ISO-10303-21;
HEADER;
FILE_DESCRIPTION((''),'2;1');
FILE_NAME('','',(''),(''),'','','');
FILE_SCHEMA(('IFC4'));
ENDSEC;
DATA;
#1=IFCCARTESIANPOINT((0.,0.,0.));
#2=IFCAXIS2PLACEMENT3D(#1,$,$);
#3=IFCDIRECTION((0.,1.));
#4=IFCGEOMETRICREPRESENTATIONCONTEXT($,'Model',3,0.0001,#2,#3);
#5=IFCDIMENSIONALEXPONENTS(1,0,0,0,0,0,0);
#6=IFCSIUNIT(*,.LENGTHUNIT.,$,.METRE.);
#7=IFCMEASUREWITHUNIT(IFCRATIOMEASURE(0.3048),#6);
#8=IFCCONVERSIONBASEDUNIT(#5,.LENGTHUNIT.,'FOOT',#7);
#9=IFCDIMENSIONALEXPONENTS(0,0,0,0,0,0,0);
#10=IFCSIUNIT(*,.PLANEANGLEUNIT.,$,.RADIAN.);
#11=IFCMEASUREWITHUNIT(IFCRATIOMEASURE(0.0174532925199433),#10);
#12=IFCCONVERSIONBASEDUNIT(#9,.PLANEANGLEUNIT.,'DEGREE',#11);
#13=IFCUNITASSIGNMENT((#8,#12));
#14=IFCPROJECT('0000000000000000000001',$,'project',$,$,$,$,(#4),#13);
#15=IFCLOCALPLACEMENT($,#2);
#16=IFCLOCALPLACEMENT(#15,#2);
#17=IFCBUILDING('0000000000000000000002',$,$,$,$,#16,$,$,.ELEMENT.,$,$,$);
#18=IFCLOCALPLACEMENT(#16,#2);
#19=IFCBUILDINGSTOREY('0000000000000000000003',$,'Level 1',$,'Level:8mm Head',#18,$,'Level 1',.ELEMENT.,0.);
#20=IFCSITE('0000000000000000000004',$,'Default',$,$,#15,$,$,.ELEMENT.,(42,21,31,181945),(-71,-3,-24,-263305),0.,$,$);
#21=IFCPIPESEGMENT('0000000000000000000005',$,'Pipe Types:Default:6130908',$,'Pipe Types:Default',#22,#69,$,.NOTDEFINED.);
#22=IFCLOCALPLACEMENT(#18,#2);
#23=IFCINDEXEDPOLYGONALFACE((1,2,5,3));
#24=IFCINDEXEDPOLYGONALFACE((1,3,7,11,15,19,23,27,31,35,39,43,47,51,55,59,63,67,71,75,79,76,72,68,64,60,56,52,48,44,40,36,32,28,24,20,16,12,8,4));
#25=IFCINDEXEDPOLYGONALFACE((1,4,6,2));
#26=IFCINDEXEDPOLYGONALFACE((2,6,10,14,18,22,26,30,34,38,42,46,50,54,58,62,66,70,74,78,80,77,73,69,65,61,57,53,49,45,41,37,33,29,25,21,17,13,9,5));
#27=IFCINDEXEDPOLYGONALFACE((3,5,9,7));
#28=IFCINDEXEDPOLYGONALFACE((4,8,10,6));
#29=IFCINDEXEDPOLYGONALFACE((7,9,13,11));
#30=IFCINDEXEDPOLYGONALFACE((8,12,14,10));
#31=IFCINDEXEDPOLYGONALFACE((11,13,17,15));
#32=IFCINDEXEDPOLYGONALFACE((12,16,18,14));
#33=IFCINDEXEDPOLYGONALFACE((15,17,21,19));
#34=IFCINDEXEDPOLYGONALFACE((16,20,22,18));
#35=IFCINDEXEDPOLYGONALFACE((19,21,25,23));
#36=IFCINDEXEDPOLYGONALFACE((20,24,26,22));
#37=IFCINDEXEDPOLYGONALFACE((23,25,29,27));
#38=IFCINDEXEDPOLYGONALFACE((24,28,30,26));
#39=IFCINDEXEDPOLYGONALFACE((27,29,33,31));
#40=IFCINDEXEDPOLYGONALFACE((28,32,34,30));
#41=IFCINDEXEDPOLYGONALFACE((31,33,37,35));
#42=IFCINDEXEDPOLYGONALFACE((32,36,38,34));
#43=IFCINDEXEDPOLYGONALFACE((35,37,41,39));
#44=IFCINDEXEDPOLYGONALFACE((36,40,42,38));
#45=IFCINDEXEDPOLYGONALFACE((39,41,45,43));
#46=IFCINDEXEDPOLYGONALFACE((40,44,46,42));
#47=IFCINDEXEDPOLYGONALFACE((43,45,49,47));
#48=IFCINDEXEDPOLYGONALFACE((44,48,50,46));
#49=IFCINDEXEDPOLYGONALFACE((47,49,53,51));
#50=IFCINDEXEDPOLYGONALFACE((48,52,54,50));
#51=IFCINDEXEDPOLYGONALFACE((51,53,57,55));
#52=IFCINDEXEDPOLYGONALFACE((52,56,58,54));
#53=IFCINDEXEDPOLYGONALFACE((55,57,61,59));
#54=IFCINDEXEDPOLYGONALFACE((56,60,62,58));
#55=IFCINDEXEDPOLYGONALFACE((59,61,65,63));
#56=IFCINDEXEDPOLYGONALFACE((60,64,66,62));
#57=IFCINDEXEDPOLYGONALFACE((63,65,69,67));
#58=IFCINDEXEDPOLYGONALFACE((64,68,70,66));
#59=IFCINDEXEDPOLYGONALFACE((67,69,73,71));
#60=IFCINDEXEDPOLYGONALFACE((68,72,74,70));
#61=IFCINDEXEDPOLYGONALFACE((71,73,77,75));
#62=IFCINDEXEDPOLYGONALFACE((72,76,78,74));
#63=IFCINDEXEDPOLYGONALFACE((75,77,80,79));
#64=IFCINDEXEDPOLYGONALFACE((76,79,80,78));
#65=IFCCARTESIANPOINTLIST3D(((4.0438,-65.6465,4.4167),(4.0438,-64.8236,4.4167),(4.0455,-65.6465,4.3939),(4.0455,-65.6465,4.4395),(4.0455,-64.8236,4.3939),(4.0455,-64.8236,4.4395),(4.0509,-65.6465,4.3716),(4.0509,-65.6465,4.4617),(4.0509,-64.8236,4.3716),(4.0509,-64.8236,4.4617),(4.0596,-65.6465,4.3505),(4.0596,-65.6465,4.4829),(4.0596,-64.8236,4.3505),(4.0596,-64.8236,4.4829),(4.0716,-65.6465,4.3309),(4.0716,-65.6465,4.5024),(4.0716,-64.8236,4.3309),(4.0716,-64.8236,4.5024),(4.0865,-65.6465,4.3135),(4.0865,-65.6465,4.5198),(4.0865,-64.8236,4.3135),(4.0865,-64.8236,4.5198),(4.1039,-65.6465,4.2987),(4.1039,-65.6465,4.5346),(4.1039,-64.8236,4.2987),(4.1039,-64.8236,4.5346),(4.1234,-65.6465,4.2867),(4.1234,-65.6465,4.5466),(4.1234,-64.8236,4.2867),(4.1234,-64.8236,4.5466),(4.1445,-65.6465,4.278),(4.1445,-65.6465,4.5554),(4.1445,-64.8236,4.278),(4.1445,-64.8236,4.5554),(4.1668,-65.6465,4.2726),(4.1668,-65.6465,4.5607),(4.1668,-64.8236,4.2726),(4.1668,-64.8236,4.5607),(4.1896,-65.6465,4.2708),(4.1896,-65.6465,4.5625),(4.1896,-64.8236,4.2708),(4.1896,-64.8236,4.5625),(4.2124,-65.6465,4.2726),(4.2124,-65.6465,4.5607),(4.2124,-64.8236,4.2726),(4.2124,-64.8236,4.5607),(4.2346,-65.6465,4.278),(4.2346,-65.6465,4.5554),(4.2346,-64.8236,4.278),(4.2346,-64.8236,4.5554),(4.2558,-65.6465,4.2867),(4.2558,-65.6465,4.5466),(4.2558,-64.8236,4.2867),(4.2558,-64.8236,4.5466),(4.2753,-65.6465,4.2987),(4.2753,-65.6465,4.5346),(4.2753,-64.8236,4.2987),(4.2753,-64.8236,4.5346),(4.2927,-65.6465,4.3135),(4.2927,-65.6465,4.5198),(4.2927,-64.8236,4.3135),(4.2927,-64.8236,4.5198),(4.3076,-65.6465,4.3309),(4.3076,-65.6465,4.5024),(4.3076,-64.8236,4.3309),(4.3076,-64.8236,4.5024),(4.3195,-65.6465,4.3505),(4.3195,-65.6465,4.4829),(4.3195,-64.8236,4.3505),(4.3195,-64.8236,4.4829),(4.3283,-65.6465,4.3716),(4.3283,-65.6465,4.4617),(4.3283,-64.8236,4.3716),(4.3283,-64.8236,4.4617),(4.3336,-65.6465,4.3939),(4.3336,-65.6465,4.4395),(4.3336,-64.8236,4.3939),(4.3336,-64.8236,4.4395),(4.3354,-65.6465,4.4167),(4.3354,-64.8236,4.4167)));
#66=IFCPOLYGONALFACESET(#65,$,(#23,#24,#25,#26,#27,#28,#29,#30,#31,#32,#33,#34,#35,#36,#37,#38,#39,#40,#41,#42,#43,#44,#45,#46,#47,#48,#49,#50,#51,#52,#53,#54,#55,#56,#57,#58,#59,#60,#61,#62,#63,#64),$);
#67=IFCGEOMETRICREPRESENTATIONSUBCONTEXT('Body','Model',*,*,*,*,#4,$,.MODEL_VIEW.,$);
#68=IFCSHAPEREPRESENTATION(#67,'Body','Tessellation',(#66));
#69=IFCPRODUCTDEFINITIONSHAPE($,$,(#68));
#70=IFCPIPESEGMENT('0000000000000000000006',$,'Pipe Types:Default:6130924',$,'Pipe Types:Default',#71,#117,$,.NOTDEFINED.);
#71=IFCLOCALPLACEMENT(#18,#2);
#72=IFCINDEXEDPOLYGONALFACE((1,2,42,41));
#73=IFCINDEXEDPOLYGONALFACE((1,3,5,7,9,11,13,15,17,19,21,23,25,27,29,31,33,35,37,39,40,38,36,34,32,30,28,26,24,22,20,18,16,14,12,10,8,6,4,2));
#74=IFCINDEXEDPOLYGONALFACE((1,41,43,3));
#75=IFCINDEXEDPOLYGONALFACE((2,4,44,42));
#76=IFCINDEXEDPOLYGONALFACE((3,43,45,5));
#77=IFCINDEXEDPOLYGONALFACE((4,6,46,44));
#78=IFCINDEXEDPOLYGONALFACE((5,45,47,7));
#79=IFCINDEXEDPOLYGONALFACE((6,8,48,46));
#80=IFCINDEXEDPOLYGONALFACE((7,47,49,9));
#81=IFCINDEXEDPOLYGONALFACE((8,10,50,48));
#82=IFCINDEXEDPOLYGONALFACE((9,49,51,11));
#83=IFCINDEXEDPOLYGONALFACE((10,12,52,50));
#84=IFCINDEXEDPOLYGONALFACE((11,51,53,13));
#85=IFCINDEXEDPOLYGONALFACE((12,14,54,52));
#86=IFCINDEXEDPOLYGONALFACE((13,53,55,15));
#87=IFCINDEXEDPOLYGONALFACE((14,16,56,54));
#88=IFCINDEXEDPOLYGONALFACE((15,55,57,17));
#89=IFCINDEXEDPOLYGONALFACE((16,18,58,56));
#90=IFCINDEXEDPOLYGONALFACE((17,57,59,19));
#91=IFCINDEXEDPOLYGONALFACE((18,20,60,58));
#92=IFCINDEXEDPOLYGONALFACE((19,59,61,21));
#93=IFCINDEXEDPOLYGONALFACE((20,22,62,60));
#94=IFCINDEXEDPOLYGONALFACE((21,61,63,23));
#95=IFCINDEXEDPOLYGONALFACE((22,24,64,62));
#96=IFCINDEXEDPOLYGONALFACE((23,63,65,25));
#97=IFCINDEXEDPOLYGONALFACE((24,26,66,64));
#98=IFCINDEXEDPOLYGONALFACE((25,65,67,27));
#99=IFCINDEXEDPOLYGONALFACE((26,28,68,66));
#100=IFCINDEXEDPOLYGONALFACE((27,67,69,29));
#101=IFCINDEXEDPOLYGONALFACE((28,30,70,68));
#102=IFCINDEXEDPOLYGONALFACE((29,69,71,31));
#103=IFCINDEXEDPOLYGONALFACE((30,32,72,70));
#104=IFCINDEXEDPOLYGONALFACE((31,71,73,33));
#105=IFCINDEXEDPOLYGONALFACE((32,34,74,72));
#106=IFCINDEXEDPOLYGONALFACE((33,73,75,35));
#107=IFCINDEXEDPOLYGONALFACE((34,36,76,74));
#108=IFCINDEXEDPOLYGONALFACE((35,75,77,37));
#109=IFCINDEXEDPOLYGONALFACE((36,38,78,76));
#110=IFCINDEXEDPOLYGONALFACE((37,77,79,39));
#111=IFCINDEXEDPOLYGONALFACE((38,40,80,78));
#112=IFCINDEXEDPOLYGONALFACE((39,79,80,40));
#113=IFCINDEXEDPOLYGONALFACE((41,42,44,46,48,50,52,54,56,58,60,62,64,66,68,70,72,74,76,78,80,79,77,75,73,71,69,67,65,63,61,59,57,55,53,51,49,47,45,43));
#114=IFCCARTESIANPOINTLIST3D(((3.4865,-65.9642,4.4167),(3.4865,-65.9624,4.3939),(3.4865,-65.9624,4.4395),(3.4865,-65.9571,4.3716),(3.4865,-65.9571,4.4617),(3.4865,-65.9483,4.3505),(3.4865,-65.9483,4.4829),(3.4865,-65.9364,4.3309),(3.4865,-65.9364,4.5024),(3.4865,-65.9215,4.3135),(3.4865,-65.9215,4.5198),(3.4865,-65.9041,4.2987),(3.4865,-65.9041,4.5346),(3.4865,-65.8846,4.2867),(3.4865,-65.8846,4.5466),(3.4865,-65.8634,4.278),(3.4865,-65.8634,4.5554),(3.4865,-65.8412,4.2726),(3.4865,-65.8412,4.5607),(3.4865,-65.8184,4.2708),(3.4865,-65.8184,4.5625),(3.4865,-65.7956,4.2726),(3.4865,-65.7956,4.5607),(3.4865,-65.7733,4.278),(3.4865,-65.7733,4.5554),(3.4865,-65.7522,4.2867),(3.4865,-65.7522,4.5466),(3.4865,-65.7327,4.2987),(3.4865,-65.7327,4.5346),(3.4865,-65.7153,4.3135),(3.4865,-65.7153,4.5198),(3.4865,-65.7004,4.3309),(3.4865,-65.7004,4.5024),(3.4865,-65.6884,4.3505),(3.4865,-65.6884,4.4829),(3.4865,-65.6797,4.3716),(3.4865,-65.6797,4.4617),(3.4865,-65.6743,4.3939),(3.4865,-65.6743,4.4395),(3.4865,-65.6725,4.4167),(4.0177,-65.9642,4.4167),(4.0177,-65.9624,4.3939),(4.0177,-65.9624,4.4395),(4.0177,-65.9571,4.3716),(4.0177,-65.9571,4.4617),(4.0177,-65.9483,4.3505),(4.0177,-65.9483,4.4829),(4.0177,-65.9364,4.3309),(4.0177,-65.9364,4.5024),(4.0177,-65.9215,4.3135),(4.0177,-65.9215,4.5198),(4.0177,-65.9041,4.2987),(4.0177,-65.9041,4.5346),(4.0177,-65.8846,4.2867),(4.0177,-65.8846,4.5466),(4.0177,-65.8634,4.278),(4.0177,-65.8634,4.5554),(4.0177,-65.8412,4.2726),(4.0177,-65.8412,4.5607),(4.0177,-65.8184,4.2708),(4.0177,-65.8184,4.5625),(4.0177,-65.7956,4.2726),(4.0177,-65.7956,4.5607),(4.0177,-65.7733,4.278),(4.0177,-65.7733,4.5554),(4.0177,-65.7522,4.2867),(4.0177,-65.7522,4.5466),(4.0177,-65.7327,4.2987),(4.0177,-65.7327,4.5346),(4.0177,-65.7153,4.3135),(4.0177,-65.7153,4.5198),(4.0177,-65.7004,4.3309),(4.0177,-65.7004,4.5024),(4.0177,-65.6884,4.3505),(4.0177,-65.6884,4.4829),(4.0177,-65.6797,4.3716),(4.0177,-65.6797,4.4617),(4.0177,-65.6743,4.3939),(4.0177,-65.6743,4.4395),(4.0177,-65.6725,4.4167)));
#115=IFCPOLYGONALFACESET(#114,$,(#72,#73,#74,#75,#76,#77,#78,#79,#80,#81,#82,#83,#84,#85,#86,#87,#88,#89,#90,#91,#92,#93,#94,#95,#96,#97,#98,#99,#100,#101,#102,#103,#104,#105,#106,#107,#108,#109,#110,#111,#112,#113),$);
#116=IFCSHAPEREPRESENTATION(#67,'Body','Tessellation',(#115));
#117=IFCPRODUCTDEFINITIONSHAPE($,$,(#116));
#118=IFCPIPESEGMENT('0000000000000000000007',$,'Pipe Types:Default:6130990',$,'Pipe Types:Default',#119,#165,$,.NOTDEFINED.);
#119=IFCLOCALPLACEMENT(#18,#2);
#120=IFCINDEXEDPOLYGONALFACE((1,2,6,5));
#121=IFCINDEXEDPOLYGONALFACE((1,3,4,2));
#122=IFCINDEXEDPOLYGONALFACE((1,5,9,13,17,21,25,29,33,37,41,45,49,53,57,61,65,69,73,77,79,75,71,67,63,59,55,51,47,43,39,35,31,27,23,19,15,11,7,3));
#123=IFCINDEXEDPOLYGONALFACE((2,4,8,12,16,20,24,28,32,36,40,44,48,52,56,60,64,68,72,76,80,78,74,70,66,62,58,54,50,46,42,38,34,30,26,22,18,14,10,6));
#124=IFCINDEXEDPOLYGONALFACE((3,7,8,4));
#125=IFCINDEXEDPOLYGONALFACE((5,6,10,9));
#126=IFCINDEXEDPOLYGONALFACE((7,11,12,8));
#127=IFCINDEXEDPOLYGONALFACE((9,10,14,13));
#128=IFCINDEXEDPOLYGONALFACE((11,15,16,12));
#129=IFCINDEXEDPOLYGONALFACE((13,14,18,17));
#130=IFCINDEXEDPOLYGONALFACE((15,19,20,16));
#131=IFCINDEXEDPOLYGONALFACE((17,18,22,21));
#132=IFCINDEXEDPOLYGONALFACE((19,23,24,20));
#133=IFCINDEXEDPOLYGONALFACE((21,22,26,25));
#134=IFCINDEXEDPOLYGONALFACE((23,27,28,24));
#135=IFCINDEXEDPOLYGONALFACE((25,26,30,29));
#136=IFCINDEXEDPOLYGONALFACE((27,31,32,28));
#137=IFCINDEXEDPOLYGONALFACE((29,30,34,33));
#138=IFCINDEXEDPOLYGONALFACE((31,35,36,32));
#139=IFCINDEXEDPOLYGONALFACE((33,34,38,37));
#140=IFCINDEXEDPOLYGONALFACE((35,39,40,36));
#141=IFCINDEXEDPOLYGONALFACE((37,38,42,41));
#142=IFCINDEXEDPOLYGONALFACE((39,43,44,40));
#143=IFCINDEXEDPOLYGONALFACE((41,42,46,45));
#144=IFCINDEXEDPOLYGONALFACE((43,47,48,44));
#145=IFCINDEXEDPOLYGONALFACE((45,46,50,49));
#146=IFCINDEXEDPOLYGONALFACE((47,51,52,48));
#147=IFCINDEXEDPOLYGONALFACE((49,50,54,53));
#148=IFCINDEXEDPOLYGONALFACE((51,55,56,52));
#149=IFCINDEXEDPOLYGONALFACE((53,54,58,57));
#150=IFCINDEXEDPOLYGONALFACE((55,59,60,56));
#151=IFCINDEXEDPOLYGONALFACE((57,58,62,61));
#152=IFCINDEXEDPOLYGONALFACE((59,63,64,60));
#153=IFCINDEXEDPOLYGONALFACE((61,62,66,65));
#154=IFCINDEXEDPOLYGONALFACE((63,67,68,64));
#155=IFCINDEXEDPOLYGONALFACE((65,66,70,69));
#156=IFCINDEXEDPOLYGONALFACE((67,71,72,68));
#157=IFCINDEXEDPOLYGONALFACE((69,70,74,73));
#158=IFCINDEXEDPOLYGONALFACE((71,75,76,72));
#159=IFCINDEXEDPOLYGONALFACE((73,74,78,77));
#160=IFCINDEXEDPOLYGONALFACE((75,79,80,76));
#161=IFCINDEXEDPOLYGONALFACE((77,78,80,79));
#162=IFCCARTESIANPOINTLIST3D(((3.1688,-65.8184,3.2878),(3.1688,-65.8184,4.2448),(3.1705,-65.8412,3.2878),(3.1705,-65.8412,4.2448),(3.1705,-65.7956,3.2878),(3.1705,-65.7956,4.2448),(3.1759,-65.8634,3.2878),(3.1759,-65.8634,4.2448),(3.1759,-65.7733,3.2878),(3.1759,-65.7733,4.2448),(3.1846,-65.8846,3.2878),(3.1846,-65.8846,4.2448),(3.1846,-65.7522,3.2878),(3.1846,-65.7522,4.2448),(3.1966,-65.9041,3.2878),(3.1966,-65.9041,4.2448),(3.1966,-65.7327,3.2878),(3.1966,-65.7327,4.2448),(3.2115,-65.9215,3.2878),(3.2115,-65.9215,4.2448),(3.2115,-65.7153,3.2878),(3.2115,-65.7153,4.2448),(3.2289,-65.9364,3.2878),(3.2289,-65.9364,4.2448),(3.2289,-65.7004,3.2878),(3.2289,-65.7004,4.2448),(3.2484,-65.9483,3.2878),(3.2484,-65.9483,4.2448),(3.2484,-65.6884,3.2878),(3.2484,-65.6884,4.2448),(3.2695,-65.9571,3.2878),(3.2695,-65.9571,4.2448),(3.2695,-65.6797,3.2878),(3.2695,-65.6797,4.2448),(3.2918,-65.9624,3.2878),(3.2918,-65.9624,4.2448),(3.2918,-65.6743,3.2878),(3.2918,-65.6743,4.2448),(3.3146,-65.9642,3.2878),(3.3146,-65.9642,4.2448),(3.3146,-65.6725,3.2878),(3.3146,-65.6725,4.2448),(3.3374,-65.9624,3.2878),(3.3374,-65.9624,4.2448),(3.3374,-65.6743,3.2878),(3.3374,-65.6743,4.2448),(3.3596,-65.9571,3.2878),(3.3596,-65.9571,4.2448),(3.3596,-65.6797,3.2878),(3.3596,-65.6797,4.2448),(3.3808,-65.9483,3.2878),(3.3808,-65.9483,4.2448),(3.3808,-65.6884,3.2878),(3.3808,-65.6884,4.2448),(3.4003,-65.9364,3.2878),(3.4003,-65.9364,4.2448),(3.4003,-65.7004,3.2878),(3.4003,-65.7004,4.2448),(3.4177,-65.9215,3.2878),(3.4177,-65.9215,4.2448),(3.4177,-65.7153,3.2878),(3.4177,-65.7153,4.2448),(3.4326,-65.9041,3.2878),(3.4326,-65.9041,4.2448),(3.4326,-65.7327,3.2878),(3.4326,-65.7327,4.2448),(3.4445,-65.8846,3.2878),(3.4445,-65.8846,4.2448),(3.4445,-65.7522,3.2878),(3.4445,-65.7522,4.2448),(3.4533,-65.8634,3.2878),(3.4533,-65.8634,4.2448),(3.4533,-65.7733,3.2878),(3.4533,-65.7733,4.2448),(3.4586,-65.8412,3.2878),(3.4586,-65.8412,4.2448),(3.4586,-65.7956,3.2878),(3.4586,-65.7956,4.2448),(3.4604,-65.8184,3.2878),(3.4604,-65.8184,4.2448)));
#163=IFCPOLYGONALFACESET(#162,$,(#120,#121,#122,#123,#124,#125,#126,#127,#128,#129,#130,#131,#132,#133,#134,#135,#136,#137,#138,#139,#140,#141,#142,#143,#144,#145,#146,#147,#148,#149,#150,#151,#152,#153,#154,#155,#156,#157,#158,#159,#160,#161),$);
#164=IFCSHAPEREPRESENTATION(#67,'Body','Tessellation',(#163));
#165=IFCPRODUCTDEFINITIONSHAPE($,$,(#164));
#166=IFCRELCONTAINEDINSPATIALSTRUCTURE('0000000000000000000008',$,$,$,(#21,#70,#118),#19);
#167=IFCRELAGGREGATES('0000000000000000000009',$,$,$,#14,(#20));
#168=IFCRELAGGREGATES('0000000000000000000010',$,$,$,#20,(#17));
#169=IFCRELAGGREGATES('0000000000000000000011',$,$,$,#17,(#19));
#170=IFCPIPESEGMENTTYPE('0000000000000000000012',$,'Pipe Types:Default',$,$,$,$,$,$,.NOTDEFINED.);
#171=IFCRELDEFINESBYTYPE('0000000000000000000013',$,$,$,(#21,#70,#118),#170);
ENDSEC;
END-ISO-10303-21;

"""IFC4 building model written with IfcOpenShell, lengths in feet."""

from ifc_helpers import new_model, entity, si_unit, converted_unit, direction, frame, origin, place, context, subcontext, project, spatial, indexed_curve, outline, extrude, type_object, element, save


model = new_model("IFC4")

# Units and contexts
model_context = context("Model", 3, precision=0.0001, world=origin(), true_north=direction((0.0, 1.0)))
body_context = subcontext(model_context, "Body", "Model", "MODEL_VIEW")
ifc_project = project(units=[converted_unit("LENGTHUNIT", "FOOT", entity("IfcRatioMeasure", 0.3048), si_unit("LENGTHUNIT", "METRE"), dimensions=[1, 0, 0, 0, 0, 0, 0]), converted_unit("PLANEANGLEUNIT", "DEGREE", entity("IfcRatioMeasure", 0.0174532925199433), si_unit("PLANEANGLEUNIT", "RADIAN"), dimensions=[0, 0, 0, 0, 0, 0, 0])], contexts=[model_context])

# Site, building, storey
site_placement = place(None, origin())
site = spatial("IfcSite", under=ifc_project, at=site_placement, Name="Default", CompositionType="ELEMENT", RefLatitude=(42, 21, 31, 181945), RefLongitude=(-71, -3, -24, -263305), RefElevation=0.0)
building_placement = place(site_placement, origin())
building = spatial("IfcBuilding", under=site, at=building_placement, CompositionType="ELEMENT")
storey_placement = place(building_placement, origin())
storey = spatial("IfcBuildingStorey", under=building, at=storey_placement, Name="Level 1", ObjectType="Level:8mm Head", LongName="Level 1", CompositionType="ELEMENT", Elevation=0.0)

# Pipe segments
pipe_segment_type = type_object("IfcPipeSegmentType", Name="Pipe Types:Default", PredefinedType="NOTDEFINED")
pipe_segment_1_placement = place(storey_placement, origin())
element("IfcPipeSegment", 1, at=pipe_segment_1_placement, inside=storey, type_object=pipe_segment_type, Name="Pipe Types:Default:6130908", ObjectType="Pipe Types:Default", PredefinedType="NOTDEFINED", context=body_context, shape_type="SweptSolid", body=[
    extrude(outline(indexed_curve([(0.1458, 0.0), (0.144, 0.0228), (0.1387, 0.0451), (0.1299, 0.0662), (0.118, 0.0857), (0.1031, 0.1031), (0.0857, 0.118), (0.0662, 0.1299), (0.0451, 0.1387), (0.0228, 0.144), (0.0, 0.1458), (-0.0228, 0.144), (-0.0451, 0.1387), (-0.0662, 0.1299), (-0.0857, 0.118), (-0.1031, 0.1031), (-0.118, 0.0857), (-0.1299, 0.0662), (-0.1387, 0.0451), (-0.144, 0.0228), (-0.1458, 0.0), (-0.144, -0.0228), (-0.1387, -0.0451), (-0.1299, -0.0662), (-0.118, -0.0857), (-0.1031, -0.1031), (-0.0857, -0.118), (-0.0662, -0.1299), (-0.0451, -0.1387), (-0.0228, -0.144), (0.0, -0.1458), (0.0228, -0.144), (0.0451, -0.1387), (0.0662, -0.1299), (0.0857, -0.118), (0.1031, -0.1031), (0.118, -0.0857), (0.1299, -0.0662), (0.1387, -0.0451), (0.144, -0.0228), (0.1458, 0.0)], self_intersect=False)), frame((4.1896, -65.6465, 4.4167), z_axis=(0.0, 1.0, 0.0), x_axis=(-1.0, 0.0, 0.0)), (0.0, 0.0, 1.0), 0.8229),
])
pipe_segment_2_placement = place(storey_placement, origin())
element("IfcPipeSegment", 2, at=pipe_segment_2_placement, inside=storey, type_object=pipe_segment_type, Name="Pipe Types:Default:6130924", ObjectType="Pipe Types:Default", PredefinedType="NOTDEFINED", context=body_context, shape_type="SweptSolid", body=[
    extrude(outline(indexed_curve([(0.1458, 0.0), (0.144, 0.0228), (0.1387, 0.0451), (0.1299, 0.0662), (0.118, 0.0857), (0.1031, 0.1031), (0.0857, 0.118), (0.0662, 0.1299), (0.0451, 0.1387), (0.0228, 0.144), (0.0, 0.1458), (-0.0228, 0.144), (-0.0451, 0.1387), (-0.0662, 0.1299), (-0.0857, 0.118), (-0.1031, 0.1031), (-0.118, 0.0857), (-0.1299, 0.0662), (-0.1387, 0.0451), (-0.144, 0.0228), (-0.1458, 0.0), (-0.144, -0.0228), (-0.1387, -0.0451), (-0.1299, -0.0662), (-0.118, -0.0857), (-0.1031, -0.1031), (-0.0857, -0.118), (-0.0662, -0.1299), (-0.0451, -0.1387), (-0.0228, -0.144), (0.0, -0.1458), (0.0228, -0.144), (0.0451, -0.1387), (0.0662, -0.1299), (0.0857, -0.118), (0.1031, -0.1031), (0.118, -0.0857), (0.1299, -0.0662), (0.1387, -0.0451), (0.144, -0.0228), (0.1458, 0.0)], self_intersect=False)), frame((3.4865, -65.8184, 4.4167), z_axis=(1.0, 0.0, 0.0), x_axis=(0.0, 1.0, 0.0)), (0.0, 0.0, 1.0), 0.5313),
])
pipe_segment_3_placement = place(storey_placement, origin())
element("IfcPipeSegment", 3, at=pipe_segment_3_placement, inside=storey, type_object=pipe_segment_type, Name="Pipe Types:Default:6130990", ObjectType="Pipe Types:Default", PredefinedType="NOTDEFINED", context=body_context, shape_type="SweptSolid", body=[
    extrude(outline(indexed_curve([(0.1458, 0.0), (0.144, 0.0228), (0.1387, 0.0451), (0.1299, 0.0662), (0.118, 0.0857), (0.1031, 0.1031), (0.0857, 0.118), (0.0662, 0.1299), (0.0451, 0.1387), (0.0228, 0.144), (0.0, 0.1458), (-0.0228, 0.144), (-0.0451, 0.1387), (-0.0662, 0.1299), (-0.0857, 0.118), (-0.1031, 0.1031), (-0.118, 0.0857), (-0.1299, 0.0662), (-0.1387, 0.0451), (-0.144, 0.0228), (-0.1458, 0.0), (-0.144, -0.0228), (-0.1387, -0.0451), (-0.1299, -0.0662), (-0.118, -0.0857), (-0.1031, -0.1031), (-0.0857, -0.118), (-0.0662, -0.1299), (-0.0451, -0.1387), (-0.0228, -0.144), (0.0, -0.1458), (0.0228, -0.144), (0.0451, -0.1387), (0.0662, -0.1299), (0.0857, -0.118), (0.1031, -0.1031), (0.118, -0.0857), (0.1299, -0.0662), (0.1387, -0.0451), (0.144, -0.0228), (0.1458, 0.0)], self_intersect=False)), frame((3.3146, -65.8184, 3.2878)), (0.0, 0.0, 1.0), 0.957),
])

save(model, "model.ifc")
